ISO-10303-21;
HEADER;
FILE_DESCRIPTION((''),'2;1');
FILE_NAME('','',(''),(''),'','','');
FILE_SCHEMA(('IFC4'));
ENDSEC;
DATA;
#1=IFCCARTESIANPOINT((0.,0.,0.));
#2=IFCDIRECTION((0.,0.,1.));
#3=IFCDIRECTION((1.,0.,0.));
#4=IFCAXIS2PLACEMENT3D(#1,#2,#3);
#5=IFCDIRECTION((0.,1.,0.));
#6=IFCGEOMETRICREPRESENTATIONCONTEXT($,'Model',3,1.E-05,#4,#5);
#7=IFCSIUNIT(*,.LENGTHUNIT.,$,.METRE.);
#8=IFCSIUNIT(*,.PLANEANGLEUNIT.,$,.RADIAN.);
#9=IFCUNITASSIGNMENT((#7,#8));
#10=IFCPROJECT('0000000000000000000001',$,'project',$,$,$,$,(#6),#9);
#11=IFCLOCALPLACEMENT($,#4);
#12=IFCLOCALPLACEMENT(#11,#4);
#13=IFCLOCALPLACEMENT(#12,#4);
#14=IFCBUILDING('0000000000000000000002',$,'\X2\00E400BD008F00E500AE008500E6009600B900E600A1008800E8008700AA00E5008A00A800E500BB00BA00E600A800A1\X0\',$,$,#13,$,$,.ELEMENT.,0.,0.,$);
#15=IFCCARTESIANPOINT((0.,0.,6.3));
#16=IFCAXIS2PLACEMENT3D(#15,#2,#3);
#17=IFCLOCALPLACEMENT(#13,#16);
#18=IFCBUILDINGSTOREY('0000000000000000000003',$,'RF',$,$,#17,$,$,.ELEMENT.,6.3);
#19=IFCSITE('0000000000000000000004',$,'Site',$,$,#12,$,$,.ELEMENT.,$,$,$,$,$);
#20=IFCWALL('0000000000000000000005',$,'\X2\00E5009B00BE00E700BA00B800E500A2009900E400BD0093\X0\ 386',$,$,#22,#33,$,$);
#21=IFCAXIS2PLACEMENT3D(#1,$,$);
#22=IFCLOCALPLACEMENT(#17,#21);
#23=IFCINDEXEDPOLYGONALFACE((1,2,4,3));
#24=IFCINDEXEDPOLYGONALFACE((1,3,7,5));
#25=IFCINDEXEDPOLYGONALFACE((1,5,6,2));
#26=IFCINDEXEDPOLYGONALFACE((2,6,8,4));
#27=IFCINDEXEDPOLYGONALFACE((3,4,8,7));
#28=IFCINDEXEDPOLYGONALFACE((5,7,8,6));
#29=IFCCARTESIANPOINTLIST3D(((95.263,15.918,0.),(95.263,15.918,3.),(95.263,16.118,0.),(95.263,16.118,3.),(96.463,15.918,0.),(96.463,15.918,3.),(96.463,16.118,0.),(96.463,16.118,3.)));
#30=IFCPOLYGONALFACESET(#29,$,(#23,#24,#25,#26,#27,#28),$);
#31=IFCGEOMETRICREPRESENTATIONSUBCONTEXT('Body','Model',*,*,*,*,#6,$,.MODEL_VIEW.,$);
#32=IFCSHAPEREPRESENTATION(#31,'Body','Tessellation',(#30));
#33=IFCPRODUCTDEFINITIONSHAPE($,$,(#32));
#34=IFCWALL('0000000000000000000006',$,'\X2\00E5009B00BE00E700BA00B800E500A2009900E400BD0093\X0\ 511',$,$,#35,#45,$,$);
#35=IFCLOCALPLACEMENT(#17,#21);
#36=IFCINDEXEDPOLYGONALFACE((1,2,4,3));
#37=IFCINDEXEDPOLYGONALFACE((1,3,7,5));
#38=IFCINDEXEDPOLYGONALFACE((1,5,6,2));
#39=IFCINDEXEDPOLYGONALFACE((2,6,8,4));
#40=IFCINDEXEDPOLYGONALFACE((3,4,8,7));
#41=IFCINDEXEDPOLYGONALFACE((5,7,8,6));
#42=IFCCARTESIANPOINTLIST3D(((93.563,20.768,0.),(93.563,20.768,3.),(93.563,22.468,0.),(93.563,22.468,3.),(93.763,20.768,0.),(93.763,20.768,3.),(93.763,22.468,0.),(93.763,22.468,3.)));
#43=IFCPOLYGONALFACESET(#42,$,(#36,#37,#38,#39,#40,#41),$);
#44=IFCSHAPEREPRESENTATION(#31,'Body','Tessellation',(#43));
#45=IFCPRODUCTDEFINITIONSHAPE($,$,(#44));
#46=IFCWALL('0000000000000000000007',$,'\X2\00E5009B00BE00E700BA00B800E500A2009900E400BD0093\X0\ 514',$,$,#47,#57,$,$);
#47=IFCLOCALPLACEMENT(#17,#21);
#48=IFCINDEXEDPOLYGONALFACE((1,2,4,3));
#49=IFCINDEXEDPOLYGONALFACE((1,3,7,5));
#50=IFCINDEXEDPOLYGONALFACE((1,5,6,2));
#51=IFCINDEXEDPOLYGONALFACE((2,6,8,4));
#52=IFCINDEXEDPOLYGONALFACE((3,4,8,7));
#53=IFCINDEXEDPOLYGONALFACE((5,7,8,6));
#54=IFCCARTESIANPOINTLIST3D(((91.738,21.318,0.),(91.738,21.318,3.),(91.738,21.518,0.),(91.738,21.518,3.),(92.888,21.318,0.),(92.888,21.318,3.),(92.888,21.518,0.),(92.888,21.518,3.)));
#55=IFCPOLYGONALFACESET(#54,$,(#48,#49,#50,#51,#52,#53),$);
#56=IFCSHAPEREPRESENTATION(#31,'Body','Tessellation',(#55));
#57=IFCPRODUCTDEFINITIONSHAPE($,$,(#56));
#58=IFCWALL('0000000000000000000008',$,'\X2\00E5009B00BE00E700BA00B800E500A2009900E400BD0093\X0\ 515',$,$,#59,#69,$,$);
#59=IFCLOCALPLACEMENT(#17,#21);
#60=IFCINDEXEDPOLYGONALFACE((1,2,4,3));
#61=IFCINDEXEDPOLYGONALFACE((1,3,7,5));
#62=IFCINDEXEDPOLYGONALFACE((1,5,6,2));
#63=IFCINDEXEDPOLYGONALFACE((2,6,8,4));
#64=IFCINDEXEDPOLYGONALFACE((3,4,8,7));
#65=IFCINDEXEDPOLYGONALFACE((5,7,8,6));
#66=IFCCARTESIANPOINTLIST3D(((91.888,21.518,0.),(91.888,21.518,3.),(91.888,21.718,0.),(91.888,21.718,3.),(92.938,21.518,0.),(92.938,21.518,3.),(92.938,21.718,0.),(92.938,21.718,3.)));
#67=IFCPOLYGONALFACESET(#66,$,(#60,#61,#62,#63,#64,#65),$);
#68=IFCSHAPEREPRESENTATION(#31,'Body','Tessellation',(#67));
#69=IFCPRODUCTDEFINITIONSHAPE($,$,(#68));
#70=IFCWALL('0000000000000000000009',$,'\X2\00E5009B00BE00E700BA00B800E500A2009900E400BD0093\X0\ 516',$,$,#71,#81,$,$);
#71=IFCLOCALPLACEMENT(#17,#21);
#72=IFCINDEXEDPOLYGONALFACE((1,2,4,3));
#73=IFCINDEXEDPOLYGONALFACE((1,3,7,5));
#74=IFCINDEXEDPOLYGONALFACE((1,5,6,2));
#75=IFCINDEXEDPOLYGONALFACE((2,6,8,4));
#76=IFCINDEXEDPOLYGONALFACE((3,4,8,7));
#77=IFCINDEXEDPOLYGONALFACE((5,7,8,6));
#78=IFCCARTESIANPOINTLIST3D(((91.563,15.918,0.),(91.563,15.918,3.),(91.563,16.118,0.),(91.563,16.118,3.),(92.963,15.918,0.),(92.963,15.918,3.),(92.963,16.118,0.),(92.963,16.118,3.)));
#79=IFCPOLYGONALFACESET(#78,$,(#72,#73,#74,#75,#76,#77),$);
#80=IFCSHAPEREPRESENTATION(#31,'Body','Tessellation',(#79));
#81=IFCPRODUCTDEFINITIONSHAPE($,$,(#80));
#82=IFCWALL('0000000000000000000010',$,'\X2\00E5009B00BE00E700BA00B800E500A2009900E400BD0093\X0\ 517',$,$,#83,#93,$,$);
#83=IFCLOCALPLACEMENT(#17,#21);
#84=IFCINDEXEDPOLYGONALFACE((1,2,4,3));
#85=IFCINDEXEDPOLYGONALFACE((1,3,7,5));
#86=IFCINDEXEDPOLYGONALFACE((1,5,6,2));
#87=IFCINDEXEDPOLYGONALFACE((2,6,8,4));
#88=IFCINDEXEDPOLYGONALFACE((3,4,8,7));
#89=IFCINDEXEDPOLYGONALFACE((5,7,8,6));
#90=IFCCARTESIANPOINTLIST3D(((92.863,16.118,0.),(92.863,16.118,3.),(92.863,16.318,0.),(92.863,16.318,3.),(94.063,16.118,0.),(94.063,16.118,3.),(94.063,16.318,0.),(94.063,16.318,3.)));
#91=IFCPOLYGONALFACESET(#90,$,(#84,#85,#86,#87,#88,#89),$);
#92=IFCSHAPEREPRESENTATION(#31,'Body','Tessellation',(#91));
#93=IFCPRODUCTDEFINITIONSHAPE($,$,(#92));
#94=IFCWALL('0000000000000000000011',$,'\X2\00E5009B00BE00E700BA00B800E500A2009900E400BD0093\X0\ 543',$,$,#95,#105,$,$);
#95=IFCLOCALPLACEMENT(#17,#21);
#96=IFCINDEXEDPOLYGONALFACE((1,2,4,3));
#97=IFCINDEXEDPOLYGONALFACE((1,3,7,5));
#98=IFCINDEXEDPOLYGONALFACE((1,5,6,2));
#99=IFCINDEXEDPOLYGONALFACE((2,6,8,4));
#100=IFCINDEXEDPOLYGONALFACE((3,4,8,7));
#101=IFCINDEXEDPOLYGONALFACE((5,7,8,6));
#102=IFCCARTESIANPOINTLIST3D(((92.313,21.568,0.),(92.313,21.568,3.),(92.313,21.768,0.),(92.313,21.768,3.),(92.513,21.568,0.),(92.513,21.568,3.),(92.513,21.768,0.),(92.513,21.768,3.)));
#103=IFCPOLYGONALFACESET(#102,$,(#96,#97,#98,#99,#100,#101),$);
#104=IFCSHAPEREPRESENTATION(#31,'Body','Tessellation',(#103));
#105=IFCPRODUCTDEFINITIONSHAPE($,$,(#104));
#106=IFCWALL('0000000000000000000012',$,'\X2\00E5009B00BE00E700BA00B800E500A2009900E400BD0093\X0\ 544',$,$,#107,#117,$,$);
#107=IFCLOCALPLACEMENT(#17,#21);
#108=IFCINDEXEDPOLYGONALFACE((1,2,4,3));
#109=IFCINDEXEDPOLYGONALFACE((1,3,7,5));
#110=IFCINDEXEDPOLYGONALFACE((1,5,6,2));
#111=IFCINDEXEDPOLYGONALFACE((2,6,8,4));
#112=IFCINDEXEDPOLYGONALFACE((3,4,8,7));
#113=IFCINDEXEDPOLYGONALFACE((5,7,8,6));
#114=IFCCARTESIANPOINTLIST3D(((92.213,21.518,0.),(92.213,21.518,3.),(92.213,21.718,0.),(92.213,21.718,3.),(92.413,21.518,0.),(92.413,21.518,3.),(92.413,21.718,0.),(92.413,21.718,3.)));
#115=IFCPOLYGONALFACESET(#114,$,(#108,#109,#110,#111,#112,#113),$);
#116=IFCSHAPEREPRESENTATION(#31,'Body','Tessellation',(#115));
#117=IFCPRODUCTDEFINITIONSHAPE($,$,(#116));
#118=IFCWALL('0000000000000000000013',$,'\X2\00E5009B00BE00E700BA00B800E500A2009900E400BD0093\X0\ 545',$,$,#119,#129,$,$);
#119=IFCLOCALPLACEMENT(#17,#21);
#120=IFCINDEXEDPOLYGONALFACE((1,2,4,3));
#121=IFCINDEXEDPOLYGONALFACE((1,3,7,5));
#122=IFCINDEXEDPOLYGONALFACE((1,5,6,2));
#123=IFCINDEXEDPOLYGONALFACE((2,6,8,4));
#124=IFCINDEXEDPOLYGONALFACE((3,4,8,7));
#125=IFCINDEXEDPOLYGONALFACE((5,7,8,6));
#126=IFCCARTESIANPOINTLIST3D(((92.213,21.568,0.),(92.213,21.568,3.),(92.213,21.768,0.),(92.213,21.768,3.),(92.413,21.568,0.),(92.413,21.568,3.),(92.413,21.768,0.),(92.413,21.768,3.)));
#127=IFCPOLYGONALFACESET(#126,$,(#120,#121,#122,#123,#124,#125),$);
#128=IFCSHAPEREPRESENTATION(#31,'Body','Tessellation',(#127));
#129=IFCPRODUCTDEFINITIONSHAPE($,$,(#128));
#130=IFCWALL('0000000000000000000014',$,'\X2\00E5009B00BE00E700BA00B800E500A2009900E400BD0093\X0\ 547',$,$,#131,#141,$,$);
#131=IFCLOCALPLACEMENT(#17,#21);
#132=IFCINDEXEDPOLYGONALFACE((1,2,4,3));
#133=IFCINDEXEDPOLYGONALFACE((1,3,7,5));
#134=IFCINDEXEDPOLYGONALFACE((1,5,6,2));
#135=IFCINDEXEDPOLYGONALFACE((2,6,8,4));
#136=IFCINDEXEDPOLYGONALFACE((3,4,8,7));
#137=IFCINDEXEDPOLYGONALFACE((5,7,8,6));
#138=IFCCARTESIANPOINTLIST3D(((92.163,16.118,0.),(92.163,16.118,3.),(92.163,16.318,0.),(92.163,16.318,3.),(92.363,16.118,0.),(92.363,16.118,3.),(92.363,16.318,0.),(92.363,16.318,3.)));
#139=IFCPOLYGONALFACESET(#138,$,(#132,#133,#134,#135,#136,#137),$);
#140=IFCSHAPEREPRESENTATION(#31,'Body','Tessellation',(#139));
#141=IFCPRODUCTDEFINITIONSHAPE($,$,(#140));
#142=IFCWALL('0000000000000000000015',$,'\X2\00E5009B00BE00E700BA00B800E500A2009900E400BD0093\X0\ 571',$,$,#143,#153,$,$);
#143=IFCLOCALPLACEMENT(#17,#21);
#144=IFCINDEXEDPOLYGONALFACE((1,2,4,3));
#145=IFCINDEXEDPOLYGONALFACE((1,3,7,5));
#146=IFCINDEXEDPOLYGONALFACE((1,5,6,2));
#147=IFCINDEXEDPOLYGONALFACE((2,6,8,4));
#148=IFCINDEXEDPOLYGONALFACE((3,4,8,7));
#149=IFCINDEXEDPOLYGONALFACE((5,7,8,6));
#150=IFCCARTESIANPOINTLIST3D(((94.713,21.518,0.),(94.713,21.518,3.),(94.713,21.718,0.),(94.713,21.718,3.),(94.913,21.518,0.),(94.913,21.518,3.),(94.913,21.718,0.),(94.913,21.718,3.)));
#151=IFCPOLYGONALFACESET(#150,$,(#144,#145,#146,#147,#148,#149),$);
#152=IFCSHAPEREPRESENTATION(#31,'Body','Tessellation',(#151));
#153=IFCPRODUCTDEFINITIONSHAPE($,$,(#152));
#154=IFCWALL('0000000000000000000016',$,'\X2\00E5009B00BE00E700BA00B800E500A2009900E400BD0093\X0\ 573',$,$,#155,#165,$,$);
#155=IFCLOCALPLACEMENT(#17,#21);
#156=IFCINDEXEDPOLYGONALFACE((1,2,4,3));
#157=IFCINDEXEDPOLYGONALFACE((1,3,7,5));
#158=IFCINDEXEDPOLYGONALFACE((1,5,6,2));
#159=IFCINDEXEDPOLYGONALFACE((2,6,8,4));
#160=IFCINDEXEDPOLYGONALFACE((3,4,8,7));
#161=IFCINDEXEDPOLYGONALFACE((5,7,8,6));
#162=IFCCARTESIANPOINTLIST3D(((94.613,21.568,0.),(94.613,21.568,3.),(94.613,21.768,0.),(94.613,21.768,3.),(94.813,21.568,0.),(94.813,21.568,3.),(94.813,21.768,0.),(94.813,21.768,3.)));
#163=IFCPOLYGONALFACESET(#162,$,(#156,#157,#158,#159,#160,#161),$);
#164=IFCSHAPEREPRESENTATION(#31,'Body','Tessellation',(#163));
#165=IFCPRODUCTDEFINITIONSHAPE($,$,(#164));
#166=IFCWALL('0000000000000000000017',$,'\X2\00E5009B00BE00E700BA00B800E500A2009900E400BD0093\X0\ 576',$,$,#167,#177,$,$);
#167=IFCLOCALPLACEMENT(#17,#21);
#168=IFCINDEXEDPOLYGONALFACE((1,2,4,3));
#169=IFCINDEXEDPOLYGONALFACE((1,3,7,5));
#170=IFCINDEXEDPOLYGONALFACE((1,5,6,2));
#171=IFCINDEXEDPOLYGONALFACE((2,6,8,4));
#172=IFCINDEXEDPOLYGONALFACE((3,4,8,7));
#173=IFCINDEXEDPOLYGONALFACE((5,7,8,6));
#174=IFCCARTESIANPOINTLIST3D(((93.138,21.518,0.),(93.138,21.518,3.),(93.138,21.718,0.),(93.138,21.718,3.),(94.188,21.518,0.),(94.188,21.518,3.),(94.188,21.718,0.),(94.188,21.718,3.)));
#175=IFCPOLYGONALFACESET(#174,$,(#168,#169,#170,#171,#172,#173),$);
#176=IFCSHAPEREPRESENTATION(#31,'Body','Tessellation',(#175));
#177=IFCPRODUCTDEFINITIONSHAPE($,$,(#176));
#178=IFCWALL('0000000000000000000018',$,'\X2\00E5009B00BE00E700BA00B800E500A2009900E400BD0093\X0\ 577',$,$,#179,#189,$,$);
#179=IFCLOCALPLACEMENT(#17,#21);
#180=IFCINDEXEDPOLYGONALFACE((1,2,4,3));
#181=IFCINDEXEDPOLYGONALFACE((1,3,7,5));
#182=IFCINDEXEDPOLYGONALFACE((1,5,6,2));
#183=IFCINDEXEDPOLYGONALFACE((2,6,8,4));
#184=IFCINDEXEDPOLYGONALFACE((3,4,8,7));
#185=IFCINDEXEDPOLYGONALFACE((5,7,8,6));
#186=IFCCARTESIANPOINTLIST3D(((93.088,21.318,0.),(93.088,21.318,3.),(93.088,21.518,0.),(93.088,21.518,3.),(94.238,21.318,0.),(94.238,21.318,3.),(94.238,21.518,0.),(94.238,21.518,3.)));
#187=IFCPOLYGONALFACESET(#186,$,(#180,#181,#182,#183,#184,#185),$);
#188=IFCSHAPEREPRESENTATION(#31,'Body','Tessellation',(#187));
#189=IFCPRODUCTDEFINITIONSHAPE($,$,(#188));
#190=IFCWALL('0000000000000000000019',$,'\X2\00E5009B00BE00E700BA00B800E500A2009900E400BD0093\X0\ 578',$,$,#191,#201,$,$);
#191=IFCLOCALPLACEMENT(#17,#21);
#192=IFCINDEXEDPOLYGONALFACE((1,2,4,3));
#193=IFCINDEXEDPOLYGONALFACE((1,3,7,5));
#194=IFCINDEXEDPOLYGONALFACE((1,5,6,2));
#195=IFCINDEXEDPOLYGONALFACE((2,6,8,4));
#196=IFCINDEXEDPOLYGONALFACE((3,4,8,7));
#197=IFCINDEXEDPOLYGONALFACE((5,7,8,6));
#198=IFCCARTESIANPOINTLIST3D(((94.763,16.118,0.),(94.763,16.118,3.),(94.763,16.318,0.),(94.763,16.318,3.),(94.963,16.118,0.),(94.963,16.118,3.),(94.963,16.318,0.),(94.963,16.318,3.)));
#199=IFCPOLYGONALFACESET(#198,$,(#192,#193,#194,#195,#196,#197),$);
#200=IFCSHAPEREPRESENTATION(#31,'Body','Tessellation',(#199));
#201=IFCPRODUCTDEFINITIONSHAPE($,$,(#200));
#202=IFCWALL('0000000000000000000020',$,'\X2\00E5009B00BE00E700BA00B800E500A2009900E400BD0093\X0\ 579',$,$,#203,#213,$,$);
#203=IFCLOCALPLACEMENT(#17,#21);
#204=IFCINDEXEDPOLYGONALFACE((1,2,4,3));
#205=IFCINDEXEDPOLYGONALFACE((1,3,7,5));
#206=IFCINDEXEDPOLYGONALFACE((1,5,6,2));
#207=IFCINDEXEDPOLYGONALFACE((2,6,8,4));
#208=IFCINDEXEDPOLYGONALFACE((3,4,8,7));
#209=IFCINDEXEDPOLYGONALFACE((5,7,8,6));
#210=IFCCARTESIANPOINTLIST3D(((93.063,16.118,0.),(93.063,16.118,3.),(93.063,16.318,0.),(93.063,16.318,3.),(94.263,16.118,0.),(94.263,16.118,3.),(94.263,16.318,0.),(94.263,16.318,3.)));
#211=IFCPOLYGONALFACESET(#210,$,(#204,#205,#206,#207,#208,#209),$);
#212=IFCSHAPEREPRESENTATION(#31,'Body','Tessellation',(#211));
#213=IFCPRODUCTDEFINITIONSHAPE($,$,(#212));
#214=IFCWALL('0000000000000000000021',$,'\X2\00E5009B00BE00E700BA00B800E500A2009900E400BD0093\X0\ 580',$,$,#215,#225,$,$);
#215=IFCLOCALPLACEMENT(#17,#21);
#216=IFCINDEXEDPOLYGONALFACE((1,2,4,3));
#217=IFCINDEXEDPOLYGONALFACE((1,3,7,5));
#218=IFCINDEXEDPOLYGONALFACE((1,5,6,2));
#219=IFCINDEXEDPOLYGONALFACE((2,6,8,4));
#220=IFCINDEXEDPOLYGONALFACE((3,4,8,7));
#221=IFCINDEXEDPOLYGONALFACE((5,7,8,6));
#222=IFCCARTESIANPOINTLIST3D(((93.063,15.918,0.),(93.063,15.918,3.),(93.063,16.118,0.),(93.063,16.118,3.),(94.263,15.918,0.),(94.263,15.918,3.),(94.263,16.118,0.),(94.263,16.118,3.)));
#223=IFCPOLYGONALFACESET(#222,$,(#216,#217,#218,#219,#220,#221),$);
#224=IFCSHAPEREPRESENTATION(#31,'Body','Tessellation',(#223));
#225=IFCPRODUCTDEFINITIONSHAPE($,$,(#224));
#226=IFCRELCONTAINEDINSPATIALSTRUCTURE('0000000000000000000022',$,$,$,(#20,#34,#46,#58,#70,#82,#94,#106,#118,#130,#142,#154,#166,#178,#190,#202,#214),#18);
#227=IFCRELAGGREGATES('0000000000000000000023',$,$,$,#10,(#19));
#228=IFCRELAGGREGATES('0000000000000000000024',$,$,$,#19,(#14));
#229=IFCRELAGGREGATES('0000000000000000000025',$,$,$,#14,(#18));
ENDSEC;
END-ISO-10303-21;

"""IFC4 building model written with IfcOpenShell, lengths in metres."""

from ifc_helpers import new_model, si_unit, direction, frame, frame_2d, origin_with_axes, place, context, subcontext, project, spatial, rectangle, extrude, element, save


model = new_model("IFC4")

# Units and contexts
model_context = context("Model", 3, precision=1e-05, world=origin_with_axes(), true_north=direction((0.0, 1.0, 0.0)))
body_context = subcontext(model_context, "Body", "Model", "MODEL_VIEW")
ifc_project = project(units=[si_unit("LENGTHUNIT", "METRE"), si_unit("PLANEANGLEUNIT", "RADIAN")], contexts=[model_context])

# Site, building, storey
placement = place(None, origin_with_axes())
site_placement = place(placement, origin_with_axes())
site = spatial("IfcSite", under=ifc_project, at=site_placement, Name="Site", CompositionType="ELEMENT")
building_placement = place(site_placement, origin_with_axes())
building = spatial("IfcBuilding", under=site, at=building_placement, Name="ä½\u008få®\u0085æ\u0096¹æ¡\u0088è\u0087ªå\u008a¨å»ºæ¨¡", CompositionType="ELEMENT", ElevationOfRefHeight=0.0, ElevationOfTerrain=0.0)
storey_placement = place(building_placement, frame((0.0, 0.0, 6.3), z_axis=(0.0, 0.0, 1.0), x_axis=(1.0, 0.0, 0.0)))
storey = spatial("IfcBuildingStorey", under=building, at=storey_placement, Name="RF", CompositionType="ELEMENT", Elevation=6.3)

# Walls
wall_1_placement = place(storey_placement, frame((95.863, 16.018, 0.0), z_axis=(0.0, 0.0, 1.0), x_axis=(1.0, 0.0, 0.0)))
element("IfcWall", 1, at=wall_1_placement, inside=storey, Name="å\u009b¾çº¸å¢\u0099ä½\u0093 386", context=body_context, shape_type="SweptSolid", body=[
    extrude(rectangle(XDim=1.2, YDim=0.2, at=frame_2d((0.0, 0.0), x_axis=(1.0, 0.0, 0.0))), frame((0.0, 0.0, 0.0), z_axis=(0.0, 0.0, 1.0)), (0.0, 0.0, 1.0), 3.0),
])
wall_2_placement = place(storey_placement, frame((93.663, 21.618, 0.0), z_axis=(0.0, 0.0, 1.0), x_axis=(0.0, 1.0, 0.0)))
element("IfcWall", 2, at=wall_2_placement, inside=storey, Name="å\u009b¾çº¸å¢\u0099ä½\u0093 511", context=body_context, shape_type="SweptSolid", body=[
    extrude(rectangle(XDim=1.7, YDim=0.2, at=frame_2d((0.0, 0.0), x_axis=(1.0, 0.0, 0.0))), frame((0.0, 0.0, 0.0), z_axis=(0.0, 0.0, 1.0)), (0.0, 0.0, 1.0), 3.0),
])
wall_3_placement = place(storey_placement, frame((92.313, 21.418, 0.0), z_axis=(0.0, 0.0, 1.0), x_axis=(1.0, 0.0, 0.0)))
element("IfcWall", 3, at=wall_3_placement, inside=storey, Name="å\u009b¾çº¸å¢\u0099ä½\u0093 514", context=body_context, shape_type="SweptSolid", body=[
    extrude(rectangle(XDim=1.15, YDim=0.2, at=frame_2d((0.0, 0.0), x_axis=(1.0, 0.0, 0.0))), frame((0.0, 0.0, 0.0), z_axis=(0.0, 0.0, 1.0)), (0.0, 0.0, 1.0), 3.0),
])
wall_4_placement = place(storey_placement, frame((92.413, 21.618, 0.0), z_axis=(0.0, 0.0, 1.0), x_axis=(1.0, 0.0, 0.0)))
element("IfcWall", 4, at=wall_4_placement, inside=storey, Name="å\u009b¾çº¸å¢\u0099ä½\u0093 515", context=body_context, shape_type="SweptSolid", body=[
    extrude(rectangle(XDim=1.05, YDim=0.2, at=frame_2d((0.0, 0.0), x_axis=(1.0, 0.0, 0.0))), frame((0.0, 0.0, 0.0), z_axis=(0.0, 0.0, 1.0)), (0.0, 0.0, 1.0), 3.0),
])
wall_5_placement = place(storey_placement, frame((92.263, 16.018, 0.0), z_axis=(0.0, 0.0, 1.0), x_axis=(1.0, 0.0, 0.0)))
element("IfcWall", 5, at=wall_5_placement, inside=storey, Name="å\u009b¾çº¸å¢\u0099ä½\u0093 516", context=body_context, shape_type="SweptSolid", body=[
    extrude(rectangle(XDim=1.4, YDim=0.2, at=frame_2d((0.0, 0.0), x_axis=(1.0, 0.0, 0.0))), frame((0.0, 0.0, 0.0), z_axis=(0.0, 0.0, 1.0)), (0.0, 0.0, 1.0), 3.0),
])
wall_6_placement = place(storey_placement, frame((93.463, 16.218, 0.0), z_axis=(0.0, 0.0, 1.0), x_axis=(-1.0, 0.0, 0.0)))
element("IfcWall", 6, at=wall_6_placement, inside=storey, Name="å\u009b¾çº¸å¢\u0099ä½\u0093 517", context=body_context, shape_type="SweptSolid", body=[
    extrude(rectangle(XDim=1.2, YDim=0.2, at=frame_2d((0.0, 0.0), x_axis=(1.0, 0.0, 0.0))), frame((0.0, 0.0, 0.0), z_axis=(0.0, 0.0, 1.0)), (0.0, 0.0, 1.0), 3.0),
])
for number, where, z_axis, x_axis, name in (
    (7, (92.413, 21.668, 0.0), (0.0, 0.0, 1.0), (-1.0, 0.0, 0.0), "å\u009b¾çº¸å¢\u0099ä½\u0093 543"),
    (8, (92.313, 21.618, 0.0), (0.0, 0.0, 1.0), (0.0, -1.0, 0.0), "å\u009b¾çº¸å¢\u0099ä½\u0093 544"),
    (9, (92.313, 21.668, 0.0), (0.0, 0.0, 1.0), (0.0, -1.0, 0.0), "å\u009b¾çº¸å¢\u0099ä½\u0093 545"),
    (10, (92.263, 16.218, 0.0), (0.0, 0.0, 1.0), (0.0, -1.0, 0.0), "å\u009b¾çº¸å¢\u0099ä½\u0093 547"),
    (11, (94.813, 21.618, 0.0), (0.0, 0.0, 1.0), (0.0, -1.0, 0.0), "å\u009b¾çº¸å¢\u0099ä½\u0093 571"),
    (12, (94.713, 21.668, 0.0), (0.0, 0.0, 1.0), (1.0, 0.0, 0.0), "å\u009b¾çº¸å¢\u0099ä½\u0093 573"),
):
    element("IfcWall", number, at=place(storey_placement, frame(where, z_axis=z_axis, x_axis=x_axis)), inside=storey, Name=name, context=body_context, shape_type="SweptSolid", body=[
        extrude(rectangle(XDim=0.2, YDim=0.2, at=frame_2d((0.0, 0.0), x_axis=(1.0, 0.0, 0.0))), frame((0.0, 0.0, 0.0), z_axis=(0.0, 0.0, 1.0)), (0.0, 0.0, 1.0), 3.0),
    ])
wall_7_placement = place(storey_placement, frame((93.663, 21.618, 0.0), z_axis=(0.0, 0.0, 1.0), x_axis=(1.0, 0.0, 0.0)))
element("IfcWall", 13, at=wall_7_placement, inside=storey, Name="å\u009b¾çº¸å¢\u0099ä½\u0093 576", context=body_context, shape_type="SweptSolid", body=[
    extrude(rectangle(XDim=1.05, YDim=0.2, at=frame_2d((0.0, 0.0), x_axis=(1.0, 0.0, 0.0))), frame((0.0, 0.0, 0.0), z_axis=(0.0, 0.0, 1.0)), (0.0, 0.0, 1.0), 3.0),
])
wall_8_placement = place(storey_placement, frame((93.663, 21.418, 0.0), z_axis=(0.0, 0.0, 1.0), x_axis=(1.0, 0.0, 0.0)))
element("IfcWall", 14, at=wall_8_placement, inside=storey, Name="å\u009b¾çº¸å¢\u0099ä½\u0093 577", context=body_context, shape_type="SweptSolid", body=[
    extrude(rectangle(XDim=1.15, YDim=0.2, at=frame_2d((0.0, 0.0), x_axis=(1.0, 0.0, 0.0))), frame((0.0, 0.0, 0.0), z_axis=(0.0, 0.0, 1.0)), (0.0, 0.0, 1.0), 3.0),
])
wall_9_placement = place(storey_placement, frame((94.863, 16.218, 0.0), z_axis=(0.0, 0.0, 1.0), x_axis=(0.0, -1.0, 0.0)))
element("IfcWall", 15, at=wall_9_placement, inside=storey, Name="å\u009b¾çº¸å¢\u0099ä½\u0093 578", context=body_context, shape_type="SweptSolid", body=[
    extrude(rectangle(XDim=0.2, YDim=0.2, at=frame_2d((0.0, 0.0), x_axis=(1.0, 0.0, 0.0))), frame((0.0, 0.0, 0.0), z_axis=(0.0, 0.0, 1.0)), (0.0, 0.0, 1.0), 3.0),
])
for number, where, z_axis, x_axis, name in (
    (16, (93.663, 16.218, 0.0), (0.0, 0.0, 1.0), (1.0, 0.0, 0.0), "å\u009b¾çº¸å¢\u0099ä½\u0093 579"),
    (17, (93.663, 16.018, 0.0), (0.0, 0.0, 1.0), (1.0, 0.0, 0.0), "å\u009b¾çº¸å¢\u0099ä½\u0093 580"),
):
    element("IfcWall", number, at=place(storey_placement, frame(where, z_axis=z_axis, x_axis=x_axis)), inside=storey, Name=name, context=body_context, shape_type="SweptSolid", body=[
        extrude(rectangle(XDim=1.2, YDim=0.2, at=frame_2d((0.0, 0.0), x_axis=(1.0, 0.0, 0.0))), frame((0.0, 0.0, 0.0), z_axis=(0.0, 0.0, 1.0)), (0.0, 0.0, 1.0), 3.0),
    ])

save(model, "model.ifc")
